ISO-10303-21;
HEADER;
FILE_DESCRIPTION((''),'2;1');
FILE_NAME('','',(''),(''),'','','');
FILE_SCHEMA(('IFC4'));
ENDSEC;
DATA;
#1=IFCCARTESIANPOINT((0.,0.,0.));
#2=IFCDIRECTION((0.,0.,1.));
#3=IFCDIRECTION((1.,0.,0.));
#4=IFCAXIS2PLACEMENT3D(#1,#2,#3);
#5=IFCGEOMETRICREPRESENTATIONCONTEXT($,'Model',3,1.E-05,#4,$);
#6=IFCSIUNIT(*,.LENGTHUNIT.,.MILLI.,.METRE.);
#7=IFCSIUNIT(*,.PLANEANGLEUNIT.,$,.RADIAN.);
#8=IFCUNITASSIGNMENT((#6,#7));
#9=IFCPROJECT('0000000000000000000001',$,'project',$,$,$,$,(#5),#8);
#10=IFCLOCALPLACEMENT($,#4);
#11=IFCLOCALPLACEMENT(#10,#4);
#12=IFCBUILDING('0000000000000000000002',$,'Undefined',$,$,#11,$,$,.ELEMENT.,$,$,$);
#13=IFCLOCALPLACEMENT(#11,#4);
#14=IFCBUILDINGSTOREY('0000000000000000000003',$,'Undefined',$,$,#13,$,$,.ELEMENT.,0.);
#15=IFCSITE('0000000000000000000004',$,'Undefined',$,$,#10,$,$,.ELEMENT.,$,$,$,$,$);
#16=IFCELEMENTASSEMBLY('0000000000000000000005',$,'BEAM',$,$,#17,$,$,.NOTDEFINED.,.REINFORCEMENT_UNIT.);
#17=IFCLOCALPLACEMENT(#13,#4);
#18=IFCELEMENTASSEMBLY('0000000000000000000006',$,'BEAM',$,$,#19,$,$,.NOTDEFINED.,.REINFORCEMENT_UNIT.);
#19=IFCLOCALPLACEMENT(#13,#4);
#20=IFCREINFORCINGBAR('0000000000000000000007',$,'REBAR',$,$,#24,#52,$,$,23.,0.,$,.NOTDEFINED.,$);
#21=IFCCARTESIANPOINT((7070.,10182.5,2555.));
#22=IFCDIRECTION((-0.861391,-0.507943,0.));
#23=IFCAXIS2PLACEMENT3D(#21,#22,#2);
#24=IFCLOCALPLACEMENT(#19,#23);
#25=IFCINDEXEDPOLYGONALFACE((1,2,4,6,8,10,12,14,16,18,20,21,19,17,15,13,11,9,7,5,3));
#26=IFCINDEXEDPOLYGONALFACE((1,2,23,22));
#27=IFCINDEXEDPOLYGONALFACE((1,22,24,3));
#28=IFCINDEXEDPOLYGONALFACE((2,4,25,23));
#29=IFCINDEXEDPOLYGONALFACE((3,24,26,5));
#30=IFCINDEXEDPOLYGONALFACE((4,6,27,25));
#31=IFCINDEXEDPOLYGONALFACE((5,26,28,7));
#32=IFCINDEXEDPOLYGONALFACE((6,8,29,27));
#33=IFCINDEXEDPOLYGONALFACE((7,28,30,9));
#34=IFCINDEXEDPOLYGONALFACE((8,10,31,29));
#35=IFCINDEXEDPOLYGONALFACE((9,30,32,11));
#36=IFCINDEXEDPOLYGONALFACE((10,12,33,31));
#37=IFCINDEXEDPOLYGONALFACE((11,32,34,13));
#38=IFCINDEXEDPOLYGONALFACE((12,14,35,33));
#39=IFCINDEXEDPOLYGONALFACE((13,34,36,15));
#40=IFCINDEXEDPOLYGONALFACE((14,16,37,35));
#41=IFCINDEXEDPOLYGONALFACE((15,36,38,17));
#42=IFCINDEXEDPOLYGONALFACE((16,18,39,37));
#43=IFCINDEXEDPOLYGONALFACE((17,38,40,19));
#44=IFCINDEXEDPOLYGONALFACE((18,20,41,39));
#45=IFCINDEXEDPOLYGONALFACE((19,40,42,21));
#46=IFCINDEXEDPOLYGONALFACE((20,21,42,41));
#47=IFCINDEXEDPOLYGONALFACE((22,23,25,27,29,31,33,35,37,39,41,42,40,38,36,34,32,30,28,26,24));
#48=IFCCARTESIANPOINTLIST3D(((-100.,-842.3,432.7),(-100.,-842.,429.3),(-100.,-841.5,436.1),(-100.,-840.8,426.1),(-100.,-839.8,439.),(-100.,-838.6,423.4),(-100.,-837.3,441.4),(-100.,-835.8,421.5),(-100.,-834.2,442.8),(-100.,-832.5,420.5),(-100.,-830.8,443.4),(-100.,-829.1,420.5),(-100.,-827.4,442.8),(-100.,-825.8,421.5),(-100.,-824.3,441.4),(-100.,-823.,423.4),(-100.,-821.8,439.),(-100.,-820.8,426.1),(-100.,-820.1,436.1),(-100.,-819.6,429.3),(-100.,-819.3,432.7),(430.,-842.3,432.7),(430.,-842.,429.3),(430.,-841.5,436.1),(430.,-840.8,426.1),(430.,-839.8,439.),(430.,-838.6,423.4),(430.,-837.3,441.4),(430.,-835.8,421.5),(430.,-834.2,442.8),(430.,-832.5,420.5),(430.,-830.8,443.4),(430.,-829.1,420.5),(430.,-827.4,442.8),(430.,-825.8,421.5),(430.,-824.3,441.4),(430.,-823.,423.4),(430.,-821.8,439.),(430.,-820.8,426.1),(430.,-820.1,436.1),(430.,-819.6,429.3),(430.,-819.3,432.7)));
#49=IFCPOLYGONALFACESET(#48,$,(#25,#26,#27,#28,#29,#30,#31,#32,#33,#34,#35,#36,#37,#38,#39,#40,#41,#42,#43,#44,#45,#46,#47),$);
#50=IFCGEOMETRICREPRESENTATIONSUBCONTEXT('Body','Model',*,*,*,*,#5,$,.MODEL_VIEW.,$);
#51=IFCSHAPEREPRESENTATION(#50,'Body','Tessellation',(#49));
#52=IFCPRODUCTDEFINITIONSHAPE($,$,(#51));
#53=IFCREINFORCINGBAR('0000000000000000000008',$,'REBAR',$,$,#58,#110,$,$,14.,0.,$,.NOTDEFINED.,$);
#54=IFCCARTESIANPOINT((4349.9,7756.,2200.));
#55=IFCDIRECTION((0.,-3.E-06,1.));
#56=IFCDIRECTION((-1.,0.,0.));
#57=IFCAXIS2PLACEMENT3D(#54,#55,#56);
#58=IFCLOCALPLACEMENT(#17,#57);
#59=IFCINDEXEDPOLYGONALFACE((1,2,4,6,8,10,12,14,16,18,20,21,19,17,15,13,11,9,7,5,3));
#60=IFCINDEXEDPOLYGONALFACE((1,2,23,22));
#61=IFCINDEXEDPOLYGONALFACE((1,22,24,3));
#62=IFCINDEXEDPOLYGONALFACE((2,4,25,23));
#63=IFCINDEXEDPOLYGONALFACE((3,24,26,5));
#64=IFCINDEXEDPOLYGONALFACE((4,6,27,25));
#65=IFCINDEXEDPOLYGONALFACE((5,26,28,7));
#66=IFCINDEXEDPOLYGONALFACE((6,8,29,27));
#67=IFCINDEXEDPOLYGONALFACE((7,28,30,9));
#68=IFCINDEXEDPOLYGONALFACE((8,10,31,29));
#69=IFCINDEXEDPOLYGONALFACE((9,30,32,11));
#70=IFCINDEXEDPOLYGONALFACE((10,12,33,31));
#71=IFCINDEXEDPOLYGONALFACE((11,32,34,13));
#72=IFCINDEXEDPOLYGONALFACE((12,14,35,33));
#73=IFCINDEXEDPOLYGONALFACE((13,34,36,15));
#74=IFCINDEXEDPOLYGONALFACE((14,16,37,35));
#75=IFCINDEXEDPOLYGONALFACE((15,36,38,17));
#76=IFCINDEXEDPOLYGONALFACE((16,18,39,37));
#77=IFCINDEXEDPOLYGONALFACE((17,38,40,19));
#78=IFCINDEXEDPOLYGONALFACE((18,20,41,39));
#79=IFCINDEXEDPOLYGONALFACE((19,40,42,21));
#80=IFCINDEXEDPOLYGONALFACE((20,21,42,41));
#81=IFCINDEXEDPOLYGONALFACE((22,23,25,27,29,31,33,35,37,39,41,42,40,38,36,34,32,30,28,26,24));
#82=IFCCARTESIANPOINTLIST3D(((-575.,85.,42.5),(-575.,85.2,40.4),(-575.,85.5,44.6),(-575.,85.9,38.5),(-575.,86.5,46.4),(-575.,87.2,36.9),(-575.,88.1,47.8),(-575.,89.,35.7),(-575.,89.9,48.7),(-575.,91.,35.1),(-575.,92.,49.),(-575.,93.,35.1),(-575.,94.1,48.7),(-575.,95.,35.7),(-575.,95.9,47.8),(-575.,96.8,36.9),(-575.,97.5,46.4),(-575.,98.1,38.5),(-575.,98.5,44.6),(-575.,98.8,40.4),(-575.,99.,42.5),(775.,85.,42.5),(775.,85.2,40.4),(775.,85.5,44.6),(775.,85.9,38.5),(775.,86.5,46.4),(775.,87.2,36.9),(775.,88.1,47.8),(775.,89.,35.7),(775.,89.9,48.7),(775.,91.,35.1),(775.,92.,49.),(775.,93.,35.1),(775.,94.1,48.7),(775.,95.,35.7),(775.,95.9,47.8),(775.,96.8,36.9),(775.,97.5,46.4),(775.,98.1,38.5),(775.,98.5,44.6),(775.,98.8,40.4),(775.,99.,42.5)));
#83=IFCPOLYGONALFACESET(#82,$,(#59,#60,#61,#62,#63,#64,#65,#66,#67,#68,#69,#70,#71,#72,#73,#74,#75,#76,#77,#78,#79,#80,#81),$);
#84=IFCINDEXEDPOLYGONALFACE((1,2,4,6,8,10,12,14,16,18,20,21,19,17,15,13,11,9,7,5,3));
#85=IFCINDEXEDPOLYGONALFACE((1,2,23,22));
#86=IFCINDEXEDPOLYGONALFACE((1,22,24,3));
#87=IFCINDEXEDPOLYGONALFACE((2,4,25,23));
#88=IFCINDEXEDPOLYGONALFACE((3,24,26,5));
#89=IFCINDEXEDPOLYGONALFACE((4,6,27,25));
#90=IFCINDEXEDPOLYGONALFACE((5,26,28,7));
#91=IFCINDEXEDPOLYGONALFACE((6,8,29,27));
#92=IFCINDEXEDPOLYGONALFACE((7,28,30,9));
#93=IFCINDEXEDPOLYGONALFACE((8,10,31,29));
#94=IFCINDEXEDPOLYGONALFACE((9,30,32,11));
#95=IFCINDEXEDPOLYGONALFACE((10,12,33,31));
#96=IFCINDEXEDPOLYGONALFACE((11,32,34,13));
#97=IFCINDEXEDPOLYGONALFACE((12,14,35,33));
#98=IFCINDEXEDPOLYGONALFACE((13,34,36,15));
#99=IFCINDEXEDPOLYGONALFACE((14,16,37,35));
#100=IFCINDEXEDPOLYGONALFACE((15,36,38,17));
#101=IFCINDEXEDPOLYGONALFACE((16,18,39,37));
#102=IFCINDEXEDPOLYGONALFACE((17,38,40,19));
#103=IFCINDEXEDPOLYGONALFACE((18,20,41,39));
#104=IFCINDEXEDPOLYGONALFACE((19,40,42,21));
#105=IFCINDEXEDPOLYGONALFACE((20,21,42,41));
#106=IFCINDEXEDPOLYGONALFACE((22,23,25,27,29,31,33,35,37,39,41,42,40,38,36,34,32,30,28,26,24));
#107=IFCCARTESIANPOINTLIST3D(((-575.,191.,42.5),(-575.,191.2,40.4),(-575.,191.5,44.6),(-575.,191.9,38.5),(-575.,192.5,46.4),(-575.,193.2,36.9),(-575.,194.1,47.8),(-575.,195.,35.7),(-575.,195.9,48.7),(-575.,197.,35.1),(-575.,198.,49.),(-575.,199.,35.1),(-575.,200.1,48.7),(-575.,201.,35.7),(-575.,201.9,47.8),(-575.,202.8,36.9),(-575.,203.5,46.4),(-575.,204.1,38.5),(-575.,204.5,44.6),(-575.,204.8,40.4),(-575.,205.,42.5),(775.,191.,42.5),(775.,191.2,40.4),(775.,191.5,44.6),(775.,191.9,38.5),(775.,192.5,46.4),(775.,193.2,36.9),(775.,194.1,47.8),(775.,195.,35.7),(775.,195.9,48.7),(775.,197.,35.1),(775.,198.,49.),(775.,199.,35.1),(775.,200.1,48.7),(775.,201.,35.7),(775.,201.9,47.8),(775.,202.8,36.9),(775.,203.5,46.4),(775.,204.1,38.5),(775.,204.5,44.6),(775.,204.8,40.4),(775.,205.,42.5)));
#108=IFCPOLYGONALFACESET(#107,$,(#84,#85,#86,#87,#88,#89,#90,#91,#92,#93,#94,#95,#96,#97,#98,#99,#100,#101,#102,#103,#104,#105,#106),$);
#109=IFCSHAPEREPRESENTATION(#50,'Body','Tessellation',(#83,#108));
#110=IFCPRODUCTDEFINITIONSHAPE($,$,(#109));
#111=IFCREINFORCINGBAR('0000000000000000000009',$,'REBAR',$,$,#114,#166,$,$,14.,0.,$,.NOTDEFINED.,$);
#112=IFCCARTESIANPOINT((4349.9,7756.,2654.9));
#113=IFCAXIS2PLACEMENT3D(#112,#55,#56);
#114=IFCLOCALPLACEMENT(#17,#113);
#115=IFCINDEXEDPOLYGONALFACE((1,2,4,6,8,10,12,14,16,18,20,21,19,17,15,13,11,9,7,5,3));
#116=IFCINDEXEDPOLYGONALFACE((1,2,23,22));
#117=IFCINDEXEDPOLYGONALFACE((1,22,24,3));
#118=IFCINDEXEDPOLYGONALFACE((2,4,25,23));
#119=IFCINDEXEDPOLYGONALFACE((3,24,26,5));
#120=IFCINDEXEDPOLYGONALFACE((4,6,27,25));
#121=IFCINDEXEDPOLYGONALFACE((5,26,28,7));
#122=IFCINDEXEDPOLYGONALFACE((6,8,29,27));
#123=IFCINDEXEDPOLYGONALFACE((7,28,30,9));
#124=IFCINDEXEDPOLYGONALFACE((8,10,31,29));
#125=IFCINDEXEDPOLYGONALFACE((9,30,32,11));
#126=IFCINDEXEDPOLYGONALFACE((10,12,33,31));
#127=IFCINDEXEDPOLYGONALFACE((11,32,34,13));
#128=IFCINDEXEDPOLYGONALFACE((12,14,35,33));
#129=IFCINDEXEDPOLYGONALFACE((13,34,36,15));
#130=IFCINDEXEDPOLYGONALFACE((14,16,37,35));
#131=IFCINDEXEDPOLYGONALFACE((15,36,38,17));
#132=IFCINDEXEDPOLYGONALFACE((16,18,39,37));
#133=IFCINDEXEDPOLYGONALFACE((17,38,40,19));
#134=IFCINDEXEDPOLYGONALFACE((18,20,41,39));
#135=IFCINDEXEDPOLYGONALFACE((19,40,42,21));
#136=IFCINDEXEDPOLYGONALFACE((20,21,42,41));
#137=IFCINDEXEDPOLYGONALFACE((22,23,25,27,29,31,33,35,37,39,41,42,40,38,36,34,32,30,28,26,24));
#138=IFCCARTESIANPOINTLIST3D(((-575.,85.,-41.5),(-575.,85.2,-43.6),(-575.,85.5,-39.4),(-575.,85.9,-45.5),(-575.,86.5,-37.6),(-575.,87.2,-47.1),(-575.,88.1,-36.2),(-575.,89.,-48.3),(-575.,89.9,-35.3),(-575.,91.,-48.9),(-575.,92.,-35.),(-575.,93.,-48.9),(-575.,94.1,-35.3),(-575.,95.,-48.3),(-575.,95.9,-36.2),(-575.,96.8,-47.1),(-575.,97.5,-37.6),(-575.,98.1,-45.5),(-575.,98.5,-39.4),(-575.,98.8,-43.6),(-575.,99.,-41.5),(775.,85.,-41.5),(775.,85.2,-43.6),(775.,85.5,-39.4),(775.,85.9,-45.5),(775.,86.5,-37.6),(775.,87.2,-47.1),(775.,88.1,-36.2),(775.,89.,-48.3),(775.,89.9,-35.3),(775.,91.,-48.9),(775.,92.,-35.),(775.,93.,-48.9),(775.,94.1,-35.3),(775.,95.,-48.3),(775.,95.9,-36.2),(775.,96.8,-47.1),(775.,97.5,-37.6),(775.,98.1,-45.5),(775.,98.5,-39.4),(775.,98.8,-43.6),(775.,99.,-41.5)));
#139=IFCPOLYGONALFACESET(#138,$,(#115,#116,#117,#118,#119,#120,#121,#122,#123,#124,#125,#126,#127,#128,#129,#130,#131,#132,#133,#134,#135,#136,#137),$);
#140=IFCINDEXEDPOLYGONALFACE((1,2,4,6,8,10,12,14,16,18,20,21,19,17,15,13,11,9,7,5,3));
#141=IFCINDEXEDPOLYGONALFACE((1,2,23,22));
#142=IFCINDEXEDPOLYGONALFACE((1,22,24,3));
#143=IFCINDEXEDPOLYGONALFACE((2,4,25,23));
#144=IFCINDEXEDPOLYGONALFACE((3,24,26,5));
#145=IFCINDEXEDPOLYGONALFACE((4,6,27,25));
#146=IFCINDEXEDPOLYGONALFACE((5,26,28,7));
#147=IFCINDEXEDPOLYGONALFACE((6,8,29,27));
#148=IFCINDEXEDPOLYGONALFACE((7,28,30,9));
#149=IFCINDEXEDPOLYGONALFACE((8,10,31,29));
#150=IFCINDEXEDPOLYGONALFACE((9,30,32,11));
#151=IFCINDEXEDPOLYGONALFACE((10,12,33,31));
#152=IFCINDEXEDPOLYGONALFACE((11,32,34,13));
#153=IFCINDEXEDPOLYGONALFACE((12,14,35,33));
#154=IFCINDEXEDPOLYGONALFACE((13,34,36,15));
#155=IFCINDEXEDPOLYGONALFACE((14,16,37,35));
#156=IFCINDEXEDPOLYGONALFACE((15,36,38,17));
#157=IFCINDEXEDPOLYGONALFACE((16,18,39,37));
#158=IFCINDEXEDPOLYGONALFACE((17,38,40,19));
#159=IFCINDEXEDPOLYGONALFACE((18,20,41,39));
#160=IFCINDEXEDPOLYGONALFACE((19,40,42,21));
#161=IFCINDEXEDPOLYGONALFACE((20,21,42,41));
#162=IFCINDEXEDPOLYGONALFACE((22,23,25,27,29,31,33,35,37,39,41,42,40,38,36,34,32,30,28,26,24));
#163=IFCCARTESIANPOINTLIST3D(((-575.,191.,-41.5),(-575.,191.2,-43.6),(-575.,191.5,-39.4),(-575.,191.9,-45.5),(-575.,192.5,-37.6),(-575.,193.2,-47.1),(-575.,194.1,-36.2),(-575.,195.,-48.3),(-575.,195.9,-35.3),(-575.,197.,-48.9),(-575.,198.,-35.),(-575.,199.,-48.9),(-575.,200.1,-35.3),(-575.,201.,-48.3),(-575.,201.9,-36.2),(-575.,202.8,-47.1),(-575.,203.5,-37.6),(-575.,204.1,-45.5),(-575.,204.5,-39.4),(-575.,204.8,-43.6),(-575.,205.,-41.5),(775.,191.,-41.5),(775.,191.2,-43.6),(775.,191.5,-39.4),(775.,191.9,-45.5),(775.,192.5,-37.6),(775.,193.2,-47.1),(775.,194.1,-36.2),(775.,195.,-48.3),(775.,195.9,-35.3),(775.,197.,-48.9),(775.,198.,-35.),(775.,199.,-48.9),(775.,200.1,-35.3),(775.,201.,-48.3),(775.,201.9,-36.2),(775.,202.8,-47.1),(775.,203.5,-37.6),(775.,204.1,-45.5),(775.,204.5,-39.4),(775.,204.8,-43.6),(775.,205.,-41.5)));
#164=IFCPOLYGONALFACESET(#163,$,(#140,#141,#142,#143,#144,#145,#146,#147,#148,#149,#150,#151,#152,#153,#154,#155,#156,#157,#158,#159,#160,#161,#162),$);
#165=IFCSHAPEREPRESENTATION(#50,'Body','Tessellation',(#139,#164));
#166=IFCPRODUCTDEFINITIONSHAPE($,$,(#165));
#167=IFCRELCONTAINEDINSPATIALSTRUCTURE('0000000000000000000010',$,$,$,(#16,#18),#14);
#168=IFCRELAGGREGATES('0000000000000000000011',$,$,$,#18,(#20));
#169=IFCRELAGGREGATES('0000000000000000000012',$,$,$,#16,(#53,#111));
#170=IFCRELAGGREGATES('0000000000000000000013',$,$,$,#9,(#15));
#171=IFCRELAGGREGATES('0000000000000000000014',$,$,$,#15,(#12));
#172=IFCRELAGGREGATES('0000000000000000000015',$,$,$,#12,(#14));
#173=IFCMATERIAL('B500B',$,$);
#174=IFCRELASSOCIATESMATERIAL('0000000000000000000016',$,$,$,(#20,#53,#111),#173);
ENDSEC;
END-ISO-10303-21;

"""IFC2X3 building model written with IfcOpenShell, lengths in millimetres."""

from ifc_helpers import new_model, entity, si_unit, frame, origin_with_axes, place, context, subcontext, project, spatial, source, transform, mapped, material, element, aggregate, save


model = new_model("IFC2X3")

# Units and contexts
model_context = context("Model", 3, precision=1e-05, world=origin_with_axes())
body_context = subcontext(model_context, "Body", "Model", "MODEL_VIEW")
ifc_project = project(units=[si_unit("LENGTHUNIT", "METRE", prefix="MILLI"), si_unit("PLANEANGLEUNIT", "RADIAN")], contexts=[model_context])

# Site, building, storey
site_placement = place(None, origin_with_axes())
site = spatial("IfcSite", under=ifc_project, at=site_placement, Name="Undefined", CompositionType="ELEMENT")
building_placement = place(site_placement, origin_with_axes())
building = spatial("IfcBuilding", under=site, at=building_placement, Name="Undefined", CompositionType="ELEMENT")
storey_placement = place(building_placement, origin_with_axes())
storey = spatial("IfcBuildingStorey", under=building, at=storey_placement, Name="Undefined", CompositionType="ELEMENT", Elevation=0.0)

# Element assembly
assembly_1_placement = place(storey_placement, origin_with_axes())
assembly_1 = element("IfcElementAssembly", 1, at=assembly_1_placement, inside=storey, Name="BEAM", AssemblyPlace="NOTDEFINED", PredefinedType="REINFORCEMENT_UNIT")

# Element assembly, reinforcing bar
ifc_material_1 = material(Name="B500B")
assembly_2_placement = place(storey_placement, origin_with_axes())
assembly_2 = element("IfcElementAssembly", 2, at=assembly_2_placement, inside=storey, Name="BEAM", AssemblyPlace="NOTDEFINED", PredefinedType="REINFORCEMENT_UNIT")
shared_shape_1 = source(origin_with_axes(), body_context, "Body", "AdvancedSweptSolid", [
    entity("IfcSweptDiskSolid", entity("IfcTrimmedCurve", entity("IfcLine", entity("IfcCartesianPoint", [0.0, 0.0, 0.0]), entity("IfcVector", entity("IfcDirection", [1.0, 0.0, 0.0]), 1.0)), [entity("IfcParameterValue", 0.0)], [entity("IfcParameterValue", 530.0)], True, "PARAMETER"), 11.5, None, 0.0, 530.0),
])
reinforcing_bar_1_placement = place(assembly_2_placement, frame((7070.0, 10182.5, 2555.0), z_axis=(-0.861391, -0.507943, 0.0), x_axis=(0.0, 0.0, 1.0)))
reinforcing_bar_1 = element("IfcReinforcingBar", 3, at=reinforcing_bar_1_placement, material=ifc_material_1, Name="REBAR", BarRole="NOTDEFINED", CrossSectionArea=0.0, NominalDiameter=23.0, context=body_context, shape_type="MappedRepresentation", body=[
    mapped(shared_shape_1, transform((-100.0, -830.8, 431.9))),
])
aggregate(assembly_2, [reinforcing_bar_1])

# Reinforcing bars
shared_shape_2 = source(origin_with_axes(), body_context, "Body", "AdvancedSweptSolid", [
    entity("IfcSweptDiskSolid", entity("IfcTrimmedCurve", entity("IfcLine", entity("IfcCartesianPoint", [0.0, 0.0, 0.0]), entity("IfcVector", entity("IfcDirection", [1.0, 0.0, 0.0]), 1.0)), [entity("IfcParameterValue", 0.0)], [entity("IfcParameterValue", 1349.999613)], True, "PARAMETER"), 7.0, None, 0.0, 1350.0),
])
shared_shape_3 = source(origin_with_axes(), body_context, "Body", "AdvancedSweptSolid", [
    entity("IfcSweptDiskSolid", entity("IfcTrimmedCurve", entity("IfcLine", entity("IfcCartesianPoint", [0.0, 0.0, 0.0]), entity("IfcVector", entity("IfcDirection", [1.0, 0.0, 0.0]), 1.0)), [entity("IfcParameterValue", 0.0)], [entity("IfcParameterValue", 1349.999613)], True, "PARAMETER"), 7.0, None, 0.0, 1350.0),
])
reinforcing_bar_2_placement = place(assembly_1_placement, frame((4349.9, 7756.0, 2200.0), z_axis=(0.0, -0.000003, 1.0), x_axis=(-1.0, 0.0, 0.0)))
reinforcing_bar_2 = element("IfcReinforcingBar", 4, at=reinforcing_bar_2_placement, material=ifc_material_1, Name="REBAR", BarRole="NOTDEFINED", CrossSectionArea=0.0, NominalDiameter=14.0, context=body_context, shape_type="MappedRepresentation", body=[
    mapped(shared_shape_2, transform((-575.0, 92.0, 42.0))),
    mapped(shared_shape_3, transform((-575.0, 198.0, 42.0))),
])
shared_shape_4 = source(origin_with_axes(), body_context, "Body", "AdvancedSweptSolid", [
    entity("IfcSweptDiskSolid", entity("IfcTrimmedCurve", entity("IfcLine", entity("IfcCartesianPoint", [0.0, 0.0, 0.0]), entity("IfcVector", entity("IfcDirection", [1.0, 0.0, 0.0]), 1.0)), [entity("IfcParameterValue", 0.0)], [entity("IfcParameterValue", 1349.999613)], True, "PARAMETER"), 7.0, None, 0.0, 1350.0),
])
shared_shape_5 = source(origin_with_axes(), body_context, "Body", "AdvancedSweptSolid", [
    entity("IfcSweptDiskSolid", entity("IfcTrimmedCurve", entity("IfcLine", entity("IfcCartesianPoint", [0.0, 0.0, 0.0]), entity("IfcVector", entity("IfcDirection", [1.0, 0.0, 0.0]), 1.0)), [entity("IfcParameterValue", 0.0)], [entity("IfcParameterValue", 1349.999613)], True, "PARAMETER"), 7.0, None, 0.0, 1350.0),
])
reinforcing_bar_3_placement = place(assembly_1_placement, frame((4349.9, 7756.0, 2654.9), z_axis=(0.0, -0.000003, 1.0), x_axis=(-1.0, 0.0, 0.0)))
reinforcing_bar_3 = element("IfcReinforcingBar", 5, at=reinforcing_bar_3_placement, material=ifc_material_1, Name="REBAR", BarRole="NOTDEFINED", CrossSectionArea=0.0, NominalDiameter=14.0, context=body_context, shape_type="MappedRepresentation", body=[
    mapped(shared_shape_4, transform((-575.0, 92.0, -42.0))),
    mapped(shared_shape_5, transform((-575.0, 198.0, -42.0))),
])
aggregate(assembly_1, [reinforcing_bar_2, reinforcing_bar_3])

save(model, "model.ifc")
